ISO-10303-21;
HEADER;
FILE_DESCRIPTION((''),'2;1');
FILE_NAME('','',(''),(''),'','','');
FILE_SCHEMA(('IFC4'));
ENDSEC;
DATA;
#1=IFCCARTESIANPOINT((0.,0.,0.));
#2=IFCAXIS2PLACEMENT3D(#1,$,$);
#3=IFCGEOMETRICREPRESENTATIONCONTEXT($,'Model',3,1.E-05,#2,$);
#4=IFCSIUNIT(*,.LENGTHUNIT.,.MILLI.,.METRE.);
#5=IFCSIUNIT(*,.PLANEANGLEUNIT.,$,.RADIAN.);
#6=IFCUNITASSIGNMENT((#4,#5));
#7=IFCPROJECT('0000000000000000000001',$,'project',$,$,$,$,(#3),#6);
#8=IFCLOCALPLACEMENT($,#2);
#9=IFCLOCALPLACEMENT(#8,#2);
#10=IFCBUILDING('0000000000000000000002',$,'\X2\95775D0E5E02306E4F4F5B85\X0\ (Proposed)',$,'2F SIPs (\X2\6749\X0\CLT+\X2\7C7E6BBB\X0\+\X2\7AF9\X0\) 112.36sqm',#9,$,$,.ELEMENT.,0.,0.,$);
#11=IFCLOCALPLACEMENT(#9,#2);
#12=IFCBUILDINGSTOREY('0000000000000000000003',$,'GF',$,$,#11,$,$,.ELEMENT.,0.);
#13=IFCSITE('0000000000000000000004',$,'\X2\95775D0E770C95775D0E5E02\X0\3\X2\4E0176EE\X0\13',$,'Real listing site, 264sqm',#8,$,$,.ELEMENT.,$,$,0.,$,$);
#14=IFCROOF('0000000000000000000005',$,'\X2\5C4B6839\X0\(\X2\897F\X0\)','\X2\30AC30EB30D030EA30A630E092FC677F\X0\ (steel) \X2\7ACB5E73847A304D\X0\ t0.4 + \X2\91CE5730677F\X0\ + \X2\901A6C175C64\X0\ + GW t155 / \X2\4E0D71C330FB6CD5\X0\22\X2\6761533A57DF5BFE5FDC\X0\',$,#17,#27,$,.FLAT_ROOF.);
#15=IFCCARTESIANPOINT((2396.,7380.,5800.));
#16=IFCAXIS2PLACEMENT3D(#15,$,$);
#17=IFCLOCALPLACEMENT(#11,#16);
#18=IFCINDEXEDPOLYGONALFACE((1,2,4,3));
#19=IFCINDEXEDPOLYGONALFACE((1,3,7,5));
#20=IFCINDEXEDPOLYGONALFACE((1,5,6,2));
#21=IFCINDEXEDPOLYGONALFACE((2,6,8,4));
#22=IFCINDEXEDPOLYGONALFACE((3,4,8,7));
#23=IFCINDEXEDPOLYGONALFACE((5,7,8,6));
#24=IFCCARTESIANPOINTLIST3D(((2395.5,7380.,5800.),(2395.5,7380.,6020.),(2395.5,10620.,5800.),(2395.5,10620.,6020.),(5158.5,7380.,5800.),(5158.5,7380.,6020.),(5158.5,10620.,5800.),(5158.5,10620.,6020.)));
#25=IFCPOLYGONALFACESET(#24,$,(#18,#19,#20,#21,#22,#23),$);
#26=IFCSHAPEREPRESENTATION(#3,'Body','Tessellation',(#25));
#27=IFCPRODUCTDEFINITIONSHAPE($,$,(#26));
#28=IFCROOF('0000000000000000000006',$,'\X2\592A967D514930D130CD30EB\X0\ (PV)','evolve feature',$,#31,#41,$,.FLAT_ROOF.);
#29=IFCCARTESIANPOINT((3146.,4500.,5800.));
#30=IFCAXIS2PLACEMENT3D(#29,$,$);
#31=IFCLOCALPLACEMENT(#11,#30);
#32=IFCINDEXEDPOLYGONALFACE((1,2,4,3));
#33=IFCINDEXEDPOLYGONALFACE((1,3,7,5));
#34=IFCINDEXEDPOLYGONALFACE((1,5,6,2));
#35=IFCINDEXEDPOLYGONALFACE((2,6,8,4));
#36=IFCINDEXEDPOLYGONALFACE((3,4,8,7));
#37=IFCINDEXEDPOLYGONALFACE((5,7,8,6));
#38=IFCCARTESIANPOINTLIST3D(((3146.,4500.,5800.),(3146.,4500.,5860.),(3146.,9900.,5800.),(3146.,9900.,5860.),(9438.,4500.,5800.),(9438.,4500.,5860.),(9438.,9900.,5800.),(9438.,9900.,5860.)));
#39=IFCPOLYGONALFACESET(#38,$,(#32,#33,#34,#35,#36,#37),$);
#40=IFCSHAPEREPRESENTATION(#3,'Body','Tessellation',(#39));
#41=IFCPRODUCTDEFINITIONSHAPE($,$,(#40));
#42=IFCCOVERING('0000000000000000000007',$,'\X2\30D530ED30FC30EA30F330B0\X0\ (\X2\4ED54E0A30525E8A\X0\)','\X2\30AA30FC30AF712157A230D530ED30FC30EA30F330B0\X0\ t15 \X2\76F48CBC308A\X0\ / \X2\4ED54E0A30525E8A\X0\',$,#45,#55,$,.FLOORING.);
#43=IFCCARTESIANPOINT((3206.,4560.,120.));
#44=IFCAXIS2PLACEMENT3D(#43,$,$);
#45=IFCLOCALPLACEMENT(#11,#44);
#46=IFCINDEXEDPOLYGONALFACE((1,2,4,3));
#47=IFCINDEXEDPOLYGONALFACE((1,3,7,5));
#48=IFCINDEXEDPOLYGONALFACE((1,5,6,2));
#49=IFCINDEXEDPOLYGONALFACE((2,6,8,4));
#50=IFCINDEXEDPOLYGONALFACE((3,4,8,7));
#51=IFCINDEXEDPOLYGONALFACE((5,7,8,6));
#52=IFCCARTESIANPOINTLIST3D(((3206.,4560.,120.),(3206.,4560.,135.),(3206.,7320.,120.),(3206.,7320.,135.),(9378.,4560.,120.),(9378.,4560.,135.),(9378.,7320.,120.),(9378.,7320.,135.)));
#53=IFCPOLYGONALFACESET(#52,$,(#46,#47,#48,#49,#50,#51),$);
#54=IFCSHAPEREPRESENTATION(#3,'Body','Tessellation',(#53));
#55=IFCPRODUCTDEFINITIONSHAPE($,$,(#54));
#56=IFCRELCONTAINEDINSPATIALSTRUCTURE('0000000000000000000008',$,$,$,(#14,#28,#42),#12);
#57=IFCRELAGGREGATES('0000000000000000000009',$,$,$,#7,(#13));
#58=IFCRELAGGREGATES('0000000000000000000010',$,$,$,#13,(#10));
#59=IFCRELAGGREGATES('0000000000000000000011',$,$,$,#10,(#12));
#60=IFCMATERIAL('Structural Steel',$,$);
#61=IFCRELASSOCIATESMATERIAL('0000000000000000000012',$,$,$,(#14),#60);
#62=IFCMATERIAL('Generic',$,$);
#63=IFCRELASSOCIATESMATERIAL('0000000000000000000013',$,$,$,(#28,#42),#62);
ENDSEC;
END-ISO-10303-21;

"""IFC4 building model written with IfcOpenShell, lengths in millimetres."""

from ifc_helpers import new_model, si_unit, frame, frame_2d, origin, place, context, project, spatial, rectangle, extrude, material, element, save


model = new_model("IFC4")

# Units and contexts
model_context = context("Model", 3, precision=1e-05, world=origin())
ifc_project = project(units=[si_unit("LENGTHUNIT", "METRE", prefix="MILLI"), si_unit("PLANEANGLEUNIT", "RADIAN")], contexts=[model_context])

# Site, building, storey
site_placement = place(None, origin())
site = spatial("IfcSite", under=ifc_project, at=site_placement, Name="長崎県長崎市3丁目13", ObjectType="Real listing site, 264sqm", CompositionType="ELEMENT", RefElevation=0.0)
building_placement = place(site_placement, origin())
building = spatial("IfcBuilding", under=site, at=building_placement, Name="長崎市の住宅 (Proposed)", ObjectType="2F SIPs (杉CLT+籾殻+竹) 112.36sqm", CompositionType="ELEMENT", ElevationOfRefHeight=0.0, ElevationOfTerrain=0.0)
storey_placement = place(building_placement, origin())
storey = spatial("IfcBuildingStorey", under=building, at=storey_placement, Name="GF", CompositionType="ELEMENT", Elevation=0.0)

# Shared definitions
ifc_material_1 = material(Name="Generic")

# Roofs
ifc_material_2 = material(Name="Structural Steel")
roof_1_placement = place(storey_placement, frame((2396.0, 7380.0, 5800.0)))
element("IfcRoof", 1, at=roof_1_placement, inside=storey, material=ifc_material_2, Name="屋根(西)", Description="ガルバリウム鋼板 (steel) 立平葺き t0.4 + 野地板 + 通気層 + GW t155 / 不燃・法22条区域対応", PredefinedType="FLAT_ROOF", context=model_context, shape_type="SweptSolid", body=[
    extrude(rectangle(XDim=2763.0, YDim=3240.0, at=frame_2d((1381.0, 1620.0))), frame((2396.0, 7380.0, 5800.0)), (0.0, 0.0, 1.0), 220.0),
])
roof_2_placement = place(storey_placement, frame((3146.0, 4500.0, 5800.0)))
element("IfcRoof", 2, at=roof_2_placement, inside=storey, material=ifc_material_1, Name="太陽光パネル (PV)", Description="evolve feature", PredefinedType="FLAT_ROOF", context=model_context, shape_type="SweptSolid", body=[
    extrude(rectangle(XDim=6292.0, YDim=5400.0, at=frame_2d((3146.0, 2700.0))), frame((3146.0, 4500.0, 5800.0)), (0.0, 0.0, 1.0), 60.0),
])

# Covering
covering_placement = place(storey_placement, frame((3206.0, 4560.0, 120.0)))
element("IfcCovering", 3, at=covering_placement, inside=storey, material=ifc_material_1, Name="フローリング (仕上げ床)", Description="オーク無垢フローリング t15 直貼り / 仕上げ床", PredefinedType="FLOORING", context=model_context, shape_type="SweptSolid", body=[
    extrude(rectangle(XDim=6172.0, YDim=2760.0, at=frame_2d((3086.0, 1380.0))), frame((3206.0, 4560.0, 120.0)), (0.0, 0.0, 1.0), 15.0),
])

save(model, "model.ifc")
